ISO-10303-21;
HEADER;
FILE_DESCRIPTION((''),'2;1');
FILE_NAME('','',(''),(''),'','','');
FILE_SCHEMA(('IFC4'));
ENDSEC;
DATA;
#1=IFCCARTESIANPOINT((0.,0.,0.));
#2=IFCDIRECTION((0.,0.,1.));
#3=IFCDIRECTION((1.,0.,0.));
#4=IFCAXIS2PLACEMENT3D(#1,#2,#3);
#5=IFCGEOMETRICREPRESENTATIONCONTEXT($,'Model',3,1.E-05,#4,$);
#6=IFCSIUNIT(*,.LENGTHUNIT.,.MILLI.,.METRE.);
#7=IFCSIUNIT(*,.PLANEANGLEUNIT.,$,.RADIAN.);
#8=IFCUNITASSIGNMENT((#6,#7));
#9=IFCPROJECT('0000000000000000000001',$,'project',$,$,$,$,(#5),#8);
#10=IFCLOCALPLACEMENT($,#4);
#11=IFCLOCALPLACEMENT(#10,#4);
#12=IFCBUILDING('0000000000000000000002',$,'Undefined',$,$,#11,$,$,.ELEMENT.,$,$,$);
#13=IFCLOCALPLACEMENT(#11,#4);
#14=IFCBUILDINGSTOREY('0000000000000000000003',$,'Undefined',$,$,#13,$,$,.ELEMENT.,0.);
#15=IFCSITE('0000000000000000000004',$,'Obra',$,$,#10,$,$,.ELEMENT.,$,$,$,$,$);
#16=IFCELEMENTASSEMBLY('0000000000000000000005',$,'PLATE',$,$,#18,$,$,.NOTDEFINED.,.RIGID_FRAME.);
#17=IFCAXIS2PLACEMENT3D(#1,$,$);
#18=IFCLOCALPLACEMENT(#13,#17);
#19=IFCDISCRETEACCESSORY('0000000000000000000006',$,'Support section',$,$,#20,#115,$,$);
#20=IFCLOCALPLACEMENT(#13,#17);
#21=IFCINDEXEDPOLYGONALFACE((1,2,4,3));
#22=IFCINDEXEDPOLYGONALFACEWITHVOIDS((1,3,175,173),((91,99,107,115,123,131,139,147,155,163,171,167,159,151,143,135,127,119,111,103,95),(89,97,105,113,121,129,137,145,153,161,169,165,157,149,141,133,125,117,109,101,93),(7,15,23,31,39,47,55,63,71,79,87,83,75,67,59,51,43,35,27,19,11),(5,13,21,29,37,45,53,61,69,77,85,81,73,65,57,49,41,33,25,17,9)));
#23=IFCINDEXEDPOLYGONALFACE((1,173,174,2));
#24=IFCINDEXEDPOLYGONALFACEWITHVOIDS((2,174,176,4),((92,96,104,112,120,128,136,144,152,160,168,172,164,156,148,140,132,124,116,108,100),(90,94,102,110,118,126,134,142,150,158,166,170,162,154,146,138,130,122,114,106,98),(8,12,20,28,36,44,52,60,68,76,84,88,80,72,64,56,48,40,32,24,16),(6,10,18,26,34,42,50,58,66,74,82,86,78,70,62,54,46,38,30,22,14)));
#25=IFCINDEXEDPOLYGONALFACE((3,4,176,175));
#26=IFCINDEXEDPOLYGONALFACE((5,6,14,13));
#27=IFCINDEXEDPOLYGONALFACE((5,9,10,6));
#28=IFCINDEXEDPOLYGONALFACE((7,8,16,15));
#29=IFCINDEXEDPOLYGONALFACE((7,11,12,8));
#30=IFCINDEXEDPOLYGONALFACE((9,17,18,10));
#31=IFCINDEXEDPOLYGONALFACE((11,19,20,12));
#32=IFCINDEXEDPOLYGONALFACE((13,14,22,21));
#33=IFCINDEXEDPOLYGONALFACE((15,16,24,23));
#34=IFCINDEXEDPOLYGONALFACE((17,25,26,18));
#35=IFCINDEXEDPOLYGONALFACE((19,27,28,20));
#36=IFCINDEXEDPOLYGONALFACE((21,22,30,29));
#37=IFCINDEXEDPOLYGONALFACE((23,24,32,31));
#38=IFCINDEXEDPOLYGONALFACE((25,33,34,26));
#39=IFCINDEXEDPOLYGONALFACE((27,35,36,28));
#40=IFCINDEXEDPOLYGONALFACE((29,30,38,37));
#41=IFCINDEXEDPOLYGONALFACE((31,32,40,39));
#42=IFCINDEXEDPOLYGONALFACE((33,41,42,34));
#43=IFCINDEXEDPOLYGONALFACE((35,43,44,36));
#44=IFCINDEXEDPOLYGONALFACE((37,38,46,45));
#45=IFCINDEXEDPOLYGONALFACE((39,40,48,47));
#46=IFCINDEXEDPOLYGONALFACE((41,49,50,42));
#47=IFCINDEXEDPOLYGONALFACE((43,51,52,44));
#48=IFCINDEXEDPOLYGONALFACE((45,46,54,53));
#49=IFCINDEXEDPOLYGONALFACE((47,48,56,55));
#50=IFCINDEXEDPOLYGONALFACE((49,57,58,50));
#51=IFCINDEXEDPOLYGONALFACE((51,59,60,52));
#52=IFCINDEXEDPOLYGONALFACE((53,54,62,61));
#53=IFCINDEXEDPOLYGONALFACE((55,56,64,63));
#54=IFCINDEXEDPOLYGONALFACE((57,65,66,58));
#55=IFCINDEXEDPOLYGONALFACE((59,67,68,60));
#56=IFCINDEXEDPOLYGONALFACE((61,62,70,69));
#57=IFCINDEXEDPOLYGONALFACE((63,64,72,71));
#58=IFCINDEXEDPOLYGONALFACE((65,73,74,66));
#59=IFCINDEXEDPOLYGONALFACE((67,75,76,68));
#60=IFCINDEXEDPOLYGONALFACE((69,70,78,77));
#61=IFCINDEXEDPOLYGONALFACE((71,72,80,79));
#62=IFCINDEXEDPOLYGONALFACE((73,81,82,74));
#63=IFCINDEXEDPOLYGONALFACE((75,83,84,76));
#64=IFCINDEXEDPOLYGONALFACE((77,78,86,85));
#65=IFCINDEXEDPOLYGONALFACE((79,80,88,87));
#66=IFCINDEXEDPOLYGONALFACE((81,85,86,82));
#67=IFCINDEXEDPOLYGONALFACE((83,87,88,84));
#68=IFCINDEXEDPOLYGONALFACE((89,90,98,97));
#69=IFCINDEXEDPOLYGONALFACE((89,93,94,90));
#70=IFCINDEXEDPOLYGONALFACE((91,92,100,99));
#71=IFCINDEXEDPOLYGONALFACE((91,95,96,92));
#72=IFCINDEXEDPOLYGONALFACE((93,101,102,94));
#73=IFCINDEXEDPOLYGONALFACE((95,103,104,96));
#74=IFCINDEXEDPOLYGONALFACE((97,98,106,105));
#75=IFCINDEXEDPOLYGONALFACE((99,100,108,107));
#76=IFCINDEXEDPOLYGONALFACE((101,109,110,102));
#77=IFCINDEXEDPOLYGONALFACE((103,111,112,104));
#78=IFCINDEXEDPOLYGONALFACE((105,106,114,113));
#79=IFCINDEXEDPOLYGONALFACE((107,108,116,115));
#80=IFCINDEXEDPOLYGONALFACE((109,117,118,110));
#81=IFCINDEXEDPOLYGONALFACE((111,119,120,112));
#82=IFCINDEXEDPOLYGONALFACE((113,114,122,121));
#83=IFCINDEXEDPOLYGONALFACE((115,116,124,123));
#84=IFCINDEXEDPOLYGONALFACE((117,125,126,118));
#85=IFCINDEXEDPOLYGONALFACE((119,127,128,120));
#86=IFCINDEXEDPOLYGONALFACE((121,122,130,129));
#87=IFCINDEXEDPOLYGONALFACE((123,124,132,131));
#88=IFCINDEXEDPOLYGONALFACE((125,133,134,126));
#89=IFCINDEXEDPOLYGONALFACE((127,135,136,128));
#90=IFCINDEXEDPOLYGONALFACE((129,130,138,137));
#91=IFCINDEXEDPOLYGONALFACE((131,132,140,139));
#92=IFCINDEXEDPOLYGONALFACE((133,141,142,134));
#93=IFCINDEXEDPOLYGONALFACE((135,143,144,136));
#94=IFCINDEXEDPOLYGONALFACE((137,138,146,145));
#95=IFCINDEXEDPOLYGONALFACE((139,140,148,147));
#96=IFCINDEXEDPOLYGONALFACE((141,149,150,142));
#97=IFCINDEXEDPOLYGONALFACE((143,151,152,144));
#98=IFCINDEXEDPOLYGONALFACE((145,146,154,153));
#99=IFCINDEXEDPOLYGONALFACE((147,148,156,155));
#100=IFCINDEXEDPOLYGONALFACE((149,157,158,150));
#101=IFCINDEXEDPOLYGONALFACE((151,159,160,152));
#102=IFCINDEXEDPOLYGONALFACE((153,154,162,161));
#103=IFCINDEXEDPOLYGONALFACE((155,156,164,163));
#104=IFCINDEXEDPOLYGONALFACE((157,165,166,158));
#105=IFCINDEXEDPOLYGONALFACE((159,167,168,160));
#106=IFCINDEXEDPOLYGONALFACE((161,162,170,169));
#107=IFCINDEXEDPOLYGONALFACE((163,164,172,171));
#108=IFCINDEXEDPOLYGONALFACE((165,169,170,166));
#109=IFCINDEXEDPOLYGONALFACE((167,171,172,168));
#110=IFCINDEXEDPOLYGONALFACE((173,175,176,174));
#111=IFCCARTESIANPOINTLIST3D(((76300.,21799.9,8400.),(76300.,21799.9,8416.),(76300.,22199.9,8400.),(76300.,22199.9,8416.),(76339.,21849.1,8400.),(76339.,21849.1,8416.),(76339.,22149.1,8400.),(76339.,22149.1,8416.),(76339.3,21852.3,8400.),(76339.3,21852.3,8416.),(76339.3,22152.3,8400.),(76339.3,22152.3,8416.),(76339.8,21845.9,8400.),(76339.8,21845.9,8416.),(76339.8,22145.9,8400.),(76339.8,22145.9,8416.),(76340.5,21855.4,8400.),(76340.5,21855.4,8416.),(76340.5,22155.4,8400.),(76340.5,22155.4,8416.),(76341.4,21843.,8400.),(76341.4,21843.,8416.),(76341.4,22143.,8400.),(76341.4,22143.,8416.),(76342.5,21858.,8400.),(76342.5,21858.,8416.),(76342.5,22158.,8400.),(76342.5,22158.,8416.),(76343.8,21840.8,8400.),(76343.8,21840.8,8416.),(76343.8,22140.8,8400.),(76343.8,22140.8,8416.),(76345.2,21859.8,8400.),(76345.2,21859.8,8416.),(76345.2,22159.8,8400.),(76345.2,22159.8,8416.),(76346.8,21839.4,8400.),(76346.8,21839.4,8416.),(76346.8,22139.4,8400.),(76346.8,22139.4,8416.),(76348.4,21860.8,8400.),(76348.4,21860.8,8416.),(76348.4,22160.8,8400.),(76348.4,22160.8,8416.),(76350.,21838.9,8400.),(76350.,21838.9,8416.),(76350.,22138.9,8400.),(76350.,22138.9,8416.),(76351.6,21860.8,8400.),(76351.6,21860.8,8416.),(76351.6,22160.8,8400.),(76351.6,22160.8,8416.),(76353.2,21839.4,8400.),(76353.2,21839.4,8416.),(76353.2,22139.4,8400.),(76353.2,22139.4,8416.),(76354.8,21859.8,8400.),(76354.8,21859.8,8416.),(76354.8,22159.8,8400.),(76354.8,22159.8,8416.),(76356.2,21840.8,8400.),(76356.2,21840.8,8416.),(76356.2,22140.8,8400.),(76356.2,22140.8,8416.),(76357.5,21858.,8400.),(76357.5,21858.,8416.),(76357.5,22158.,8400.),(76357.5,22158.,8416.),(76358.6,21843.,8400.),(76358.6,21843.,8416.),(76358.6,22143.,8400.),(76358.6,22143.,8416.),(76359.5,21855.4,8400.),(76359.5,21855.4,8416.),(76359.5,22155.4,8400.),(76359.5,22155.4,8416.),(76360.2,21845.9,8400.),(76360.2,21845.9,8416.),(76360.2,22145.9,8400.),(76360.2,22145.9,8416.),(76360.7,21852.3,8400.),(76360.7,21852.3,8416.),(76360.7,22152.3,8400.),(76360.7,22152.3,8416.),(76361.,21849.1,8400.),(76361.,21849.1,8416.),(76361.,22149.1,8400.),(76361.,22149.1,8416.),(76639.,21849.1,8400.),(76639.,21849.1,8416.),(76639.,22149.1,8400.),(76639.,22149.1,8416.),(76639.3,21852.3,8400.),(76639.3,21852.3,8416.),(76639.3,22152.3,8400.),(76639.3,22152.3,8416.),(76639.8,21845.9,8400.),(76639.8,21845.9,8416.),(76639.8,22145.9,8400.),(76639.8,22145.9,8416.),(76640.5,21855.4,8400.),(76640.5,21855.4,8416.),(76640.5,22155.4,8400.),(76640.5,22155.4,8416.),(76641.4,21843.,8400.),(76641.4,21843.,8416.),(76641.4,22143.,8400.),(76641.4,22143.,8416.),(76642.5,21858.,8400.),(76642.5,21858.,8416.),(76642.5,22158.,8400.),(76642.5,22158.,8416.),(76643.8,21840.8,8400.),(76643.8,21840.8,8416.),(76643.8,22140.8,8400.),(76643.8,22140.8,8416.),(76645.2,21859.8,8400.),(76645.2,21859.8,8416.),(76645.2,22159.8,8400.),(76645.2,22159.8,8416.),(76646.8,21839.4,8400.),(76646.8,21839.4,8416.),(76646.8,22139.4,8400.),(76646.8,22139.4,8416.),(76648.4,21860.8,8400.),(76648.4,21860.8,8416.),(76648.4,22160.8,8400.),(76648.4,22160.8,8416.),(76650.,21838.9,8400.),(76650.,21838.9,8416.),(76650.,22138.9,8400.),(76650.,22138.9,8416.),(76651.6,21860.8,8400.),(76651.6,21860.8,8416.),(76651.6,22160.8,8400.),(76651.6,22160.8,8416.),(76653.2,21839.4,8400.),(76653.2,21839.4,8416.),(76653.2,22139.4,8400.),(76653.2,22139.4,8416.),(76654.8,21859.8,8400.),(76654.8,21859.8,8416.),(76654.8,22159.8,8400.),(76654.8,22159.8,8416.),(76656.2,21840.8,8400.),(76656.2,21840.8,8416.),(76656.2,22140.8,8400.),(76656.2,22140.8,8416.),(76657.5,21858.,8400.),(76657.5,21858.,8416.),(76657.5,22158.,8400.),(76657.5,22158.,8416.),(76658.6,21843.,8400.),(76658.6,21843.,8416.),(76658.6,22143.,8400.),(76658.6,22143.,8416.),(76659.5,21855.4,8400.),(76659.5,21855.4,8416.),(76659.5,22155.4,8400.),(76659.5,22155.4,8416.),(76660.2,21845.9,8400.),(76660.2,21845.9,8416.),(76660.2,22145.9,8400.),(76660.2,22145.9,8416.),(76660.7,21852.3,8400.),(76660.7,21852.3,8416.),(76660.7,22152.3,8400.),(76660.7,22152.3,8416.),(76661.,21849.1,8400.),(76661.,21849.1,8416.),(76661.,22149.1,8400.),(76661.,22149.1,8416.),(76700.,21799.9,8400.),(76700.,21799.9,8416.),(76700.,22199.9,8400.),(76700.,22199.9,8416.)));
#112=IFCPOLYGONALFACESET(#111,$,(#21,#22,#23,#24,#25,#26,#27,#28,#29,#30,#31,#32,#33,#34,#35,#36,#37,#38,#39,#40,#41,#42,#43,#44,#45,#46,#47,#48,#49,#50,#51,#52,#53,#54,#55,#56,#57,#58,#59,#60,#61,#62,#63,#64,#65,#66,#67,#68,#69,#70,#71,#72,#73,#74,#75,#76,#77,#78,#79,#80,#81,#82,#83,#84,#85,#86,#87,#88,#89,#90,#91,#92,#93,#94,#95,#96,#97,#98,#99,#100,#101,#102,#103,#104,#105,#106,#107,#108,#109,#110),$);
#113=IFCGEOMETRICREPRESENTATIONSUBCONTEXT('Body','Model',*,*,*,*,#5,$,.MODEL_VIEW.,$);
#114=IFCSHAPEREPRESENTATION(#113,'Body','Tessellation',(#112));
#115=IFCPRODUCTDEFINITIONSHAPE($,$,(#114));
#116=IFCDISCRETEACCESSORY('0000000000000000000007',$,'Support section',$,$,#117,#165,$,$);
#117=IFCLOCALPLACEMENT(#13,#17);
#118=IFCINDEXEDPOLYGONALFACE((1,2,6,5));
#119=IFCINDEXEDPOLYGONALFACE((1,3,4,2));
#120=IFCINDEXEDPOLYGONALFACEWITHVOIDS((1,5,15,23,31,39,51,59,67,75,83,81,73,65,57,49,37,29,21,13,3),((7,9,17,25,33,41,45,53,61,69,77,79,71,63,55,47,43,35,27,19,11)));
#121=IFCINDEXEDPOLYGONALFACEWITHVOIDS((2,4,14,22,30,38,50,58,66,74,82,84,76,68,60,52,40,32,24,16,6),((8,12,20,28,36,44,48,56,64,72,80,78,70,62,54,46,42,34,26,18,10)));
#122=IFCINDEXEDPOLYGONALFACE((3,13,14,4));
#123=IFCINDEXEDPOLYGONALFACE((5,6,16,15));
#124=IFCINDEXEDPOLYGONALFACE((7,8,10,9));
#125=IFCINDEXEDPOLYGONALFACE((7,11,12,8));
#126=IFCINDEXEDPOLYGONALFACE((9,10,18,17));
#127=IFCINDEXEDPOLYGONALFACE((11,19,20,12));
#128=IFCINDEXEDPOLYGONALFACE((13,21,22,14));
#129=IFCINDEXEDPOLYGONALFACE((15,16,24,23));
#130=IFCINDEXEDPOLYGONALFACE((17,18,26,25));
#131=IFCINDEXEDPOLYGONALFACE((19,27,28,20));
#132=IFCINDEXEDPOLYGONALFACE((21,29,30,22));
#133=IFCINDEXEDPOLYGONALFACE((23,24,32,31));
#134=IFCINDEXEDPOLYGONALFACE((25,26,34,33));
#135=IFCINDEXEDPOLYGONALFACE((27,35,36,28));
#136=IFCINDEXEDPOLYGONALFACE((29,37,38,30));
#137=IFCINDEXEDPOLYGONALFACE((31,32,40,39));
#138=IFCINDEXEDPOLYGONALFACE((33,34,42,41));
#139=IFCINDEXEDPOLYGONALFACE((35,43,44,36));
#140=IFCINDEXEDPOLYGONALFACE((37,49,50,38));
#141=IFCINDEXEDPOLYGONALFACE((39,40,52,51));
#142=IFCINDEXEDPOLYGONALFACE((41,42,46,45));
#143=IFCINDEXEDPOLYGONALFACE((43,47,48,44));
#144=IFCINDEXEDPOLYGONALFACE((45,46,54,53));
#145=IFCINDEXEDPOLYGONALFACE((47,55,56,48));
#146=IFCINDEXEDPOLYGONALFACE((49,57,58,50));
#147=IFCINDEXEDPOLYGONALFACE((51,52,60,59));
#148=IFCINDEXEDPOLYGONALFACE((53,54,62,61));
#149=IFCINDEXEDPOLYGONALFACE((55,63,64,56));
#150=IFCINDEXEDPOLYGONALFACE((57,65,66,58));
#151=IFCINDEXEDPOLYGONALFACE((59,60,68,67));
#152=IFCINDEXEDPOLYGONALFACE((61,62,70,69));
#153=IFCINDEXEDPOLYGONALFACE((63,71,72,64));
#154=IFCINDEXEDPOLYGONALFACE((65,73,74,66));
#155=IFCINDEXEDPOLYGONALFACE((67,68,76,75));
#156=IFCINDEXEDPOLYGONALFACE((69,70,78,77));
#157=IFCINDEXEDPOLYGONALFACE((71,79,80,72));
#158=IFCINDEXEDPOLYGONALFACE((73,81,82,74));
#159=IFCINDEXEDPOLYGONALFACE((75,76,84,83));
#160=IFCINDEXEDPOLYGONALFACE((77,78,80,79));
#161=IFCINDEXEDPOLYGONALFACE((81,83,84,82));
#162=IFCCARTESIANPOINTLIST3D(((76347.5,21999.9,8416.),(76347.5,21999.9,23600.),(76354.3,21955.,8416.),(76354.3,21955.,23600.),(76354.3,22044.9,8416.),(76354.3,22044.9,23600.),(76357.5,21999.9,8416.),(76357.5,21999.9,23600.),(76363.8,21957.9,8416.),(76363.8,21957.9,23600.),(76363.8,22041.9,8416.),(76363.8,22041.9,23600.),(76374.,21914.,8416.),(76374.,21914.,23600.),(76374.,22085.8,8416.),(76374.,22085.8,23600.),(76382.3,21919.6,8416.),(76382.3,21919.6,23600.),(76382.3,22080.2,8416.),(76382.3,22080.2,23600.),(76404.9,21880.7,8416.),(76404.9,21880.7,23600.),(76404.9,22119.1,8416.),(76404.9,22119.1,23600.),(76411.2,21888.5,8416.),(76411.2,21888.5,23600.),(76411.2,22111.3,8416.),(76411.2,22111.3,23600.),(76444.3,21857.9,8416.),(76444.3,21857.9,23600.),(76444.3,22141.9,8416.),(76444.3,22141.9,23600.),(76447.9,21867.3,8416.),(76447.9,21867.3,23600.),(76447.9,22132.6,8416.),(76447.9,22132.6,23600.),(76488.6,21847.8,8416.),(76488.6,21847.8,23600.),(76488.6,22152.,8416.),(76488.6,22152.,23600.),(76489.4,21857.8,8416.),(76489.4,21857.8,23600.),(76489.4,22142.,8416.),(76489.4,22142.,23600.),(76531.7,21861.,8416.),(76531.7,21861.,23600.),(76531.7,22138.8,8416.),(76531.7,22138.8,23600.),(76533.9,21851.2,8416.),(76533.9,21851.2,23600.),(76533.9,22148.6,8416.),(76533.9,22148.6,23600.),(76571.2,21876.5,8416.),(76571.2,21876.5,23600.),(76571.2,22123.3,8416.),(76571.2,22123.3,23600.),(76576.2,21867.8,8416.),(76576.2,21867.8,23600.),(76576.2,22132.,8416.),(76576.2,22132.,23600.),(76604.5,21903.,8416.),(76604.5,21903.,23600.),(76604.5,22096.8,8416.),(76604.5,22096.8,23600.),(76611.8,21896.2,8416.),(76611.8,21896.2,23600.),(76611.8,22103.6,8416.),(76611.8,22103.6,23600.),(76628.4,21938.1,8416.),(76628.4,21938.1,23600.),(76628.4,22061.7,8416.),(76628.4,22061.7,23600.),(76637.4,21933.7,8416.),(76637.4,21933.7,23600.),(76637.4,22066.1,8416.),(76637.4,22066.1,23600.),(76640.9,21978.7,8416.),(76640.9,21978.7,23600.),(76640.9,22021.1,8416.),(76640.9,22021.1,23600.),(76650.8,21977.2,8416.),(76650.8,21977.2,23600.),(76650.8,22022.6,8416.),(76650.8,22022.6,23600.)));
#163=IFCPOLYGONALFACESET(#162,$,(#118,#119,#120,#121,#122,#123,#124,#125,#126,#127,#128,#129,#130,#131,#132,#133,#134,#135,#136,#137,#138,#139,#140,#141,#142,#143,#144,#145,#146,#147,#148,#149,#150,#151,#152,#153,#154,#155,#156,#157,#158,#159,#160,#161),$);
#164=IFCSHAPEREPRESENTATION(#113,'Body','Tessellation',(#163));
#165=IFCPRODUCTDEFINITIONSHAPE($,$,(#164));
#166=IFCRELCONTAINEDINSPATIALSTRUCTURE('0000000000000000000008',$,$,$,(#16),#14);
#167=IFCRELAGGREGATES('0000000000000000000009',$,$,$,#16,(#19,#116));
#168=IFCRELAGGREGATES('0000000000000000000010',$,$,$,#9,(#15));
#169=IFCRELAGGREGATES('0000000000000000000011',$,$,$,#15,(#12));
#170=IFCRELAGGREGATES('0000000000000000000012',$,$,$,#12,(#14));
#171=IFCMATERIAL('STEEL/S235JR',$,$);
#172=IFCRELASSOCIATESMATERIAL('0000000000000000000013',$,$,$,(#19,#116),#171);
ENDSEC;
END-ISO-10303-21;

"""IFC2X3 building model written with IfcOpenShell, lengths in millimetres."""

from ifc_helpers import new_model, si_unit, frame, origin_with_axes, origin_2d_with_axis, place, context, subcontext, project, spatial, rectangle, circle, hollow_circle, extrude, clip, halfspace, source, transform, mapped, material, element, aggregate, save


model = new_model("IFC2X3")

# Units and contexts
model_context = context("Model", 3, precision=1e-05, world=origin_with_axes())
body_context = subcontext(model_context, "Body", "Model", "MODEL_VIEW")
ifc_project = project(units=[si_unit("LENGTHUNIT", "METRE", prefix="MILLI"), si_unit("PLANEANGLEUNIT", "RADIAN")], contexts=[model_context])

# Site, building, storey
site_placement = place(None, origin_with_axes())
site = spatial("IfcSite", under=ifc_project, at=site_placement, Name="Obra", CompositionType="ELEMENT")
building_placement = place(site_placement, origin_with_axes())
building = spatial("IfcBuilding", under=site, at=building_placement, Name="Undefined", CompositionType="ELEMENT")
storey_placement = place(building_placement, origin_with_axes())
storey = spatial("IfcBuildingStorey", under=building, at=storey_placement, Name="Undefined", CompositionType="ELEMENT", Elevation=0.0)

# Shared definitions
ifc_material_1 = material(Name="STEEL/S235JR")

# Element assembly, discrete accessories, opening
assembly_1_placement = place(storey_placement, origin_with_axes())
assembly_1 = element("IfcElementAssembly", 1, at=assembly_1_placement, inside=storey, Name="PLATE", AssemblyPlace="NOTDEFINED", PredefinedType="RIGID_FRAME")
discrete_accessory_1_placement = place(assembly_1_placement, frame((76500.0, 21799.9, 8408.0), z_axis=(-1.0, 0.0, 0.0), x_axis=(0.0, 1.0, 0.0)))
discrete_accessory_1 = element("IfcDiscreteAccessory", 2, at=discrete_accessory_1_placement, material=ifc_material_1, Name="Support section", context=body_context, shape_type="SweptSolid", body=[
    extrude(rectangle(XDim=16.0, YDim=400.0, at=origin_2d_with_axis()), frame((400.0, 0.0, 0.0), z_axis=(-1.0, 0.0, 0.0), x_axis=(0.0, -1.0, 0.0)), (0.0, 0.0, 1.0), 400.0),
])
shared_shape_1 = source(origin_with_axes(), body_context, "Body", "SweptSolid", [
    extrude(circle(Radius=11.0, at=origin_2d_with_axis()), frame((0.0, -0.1, 0.0), z_axis=(0.0, 1.0, 0.0), x_axis=(1.0, 0.0, 0.0)), (0.0, 0.0, 1.0), 16.2),
])
opening_1_placement = place(assembly_1_placement, frame((76500.0, 22152.4, 8416.0), z_axis=(1.0, 0.0, 0.0), x_axis=(0.0, -1.0, 0.0)))
element("IfcOpeningElement", 3, at=opening_1_placement, cuts=discrete_accessory_1, ObjectType="Opening", context=body_context, shape_type="MappedRepresentation", body=[
    mapped(shared_shape_1, transform((2.5, 0.0, 150.0))),
    mapped(shared_shape_1, transform((2.5, 0.0, -150.0))),
    mapped(shared_shape_1, transform((302.5, 0.0, 150.0))),
    mapped(shared_shape_1, transform((302.5, 0.0, -150.0))),
])
discrete_accessory_2_placement = place(assembly_1_placement, frame((76500.0, 21999.9, 8400.0), z_axis=(0.0, 0.0, 1.0), x_axis=(0.0, 1.0, 0.0)))
discrete_accessory_2 = element("IfcDiscreteAccessory", 4, at=discrete_accessory_2_placement, material=ifc_material_1, Name="Support section", context=body_context, shape_type="Clipping", body=[
    clip(extrude(hollow_circle(Radius=152.5, WallThickness=10.0, at=origin_2d_with_axis()), frame((0.0, 0.0, 15200.0), z_axis=(0.0, 0.0, -1.0), x_axis=(0.0, 1.0, 0.0)), (0.0, 0.0, 1.0), 15184.0), halfspace(frame((-152.5, 0.0, 16.0), z_axis=(0.0, 0.0, 1.0), x_axis=(0.0, 1.0, 0.0)), True)),
])
aggregate(assembly_1, [discrete_accessory_1, discrete_accessory_2])

save(model, "model.ifc")
